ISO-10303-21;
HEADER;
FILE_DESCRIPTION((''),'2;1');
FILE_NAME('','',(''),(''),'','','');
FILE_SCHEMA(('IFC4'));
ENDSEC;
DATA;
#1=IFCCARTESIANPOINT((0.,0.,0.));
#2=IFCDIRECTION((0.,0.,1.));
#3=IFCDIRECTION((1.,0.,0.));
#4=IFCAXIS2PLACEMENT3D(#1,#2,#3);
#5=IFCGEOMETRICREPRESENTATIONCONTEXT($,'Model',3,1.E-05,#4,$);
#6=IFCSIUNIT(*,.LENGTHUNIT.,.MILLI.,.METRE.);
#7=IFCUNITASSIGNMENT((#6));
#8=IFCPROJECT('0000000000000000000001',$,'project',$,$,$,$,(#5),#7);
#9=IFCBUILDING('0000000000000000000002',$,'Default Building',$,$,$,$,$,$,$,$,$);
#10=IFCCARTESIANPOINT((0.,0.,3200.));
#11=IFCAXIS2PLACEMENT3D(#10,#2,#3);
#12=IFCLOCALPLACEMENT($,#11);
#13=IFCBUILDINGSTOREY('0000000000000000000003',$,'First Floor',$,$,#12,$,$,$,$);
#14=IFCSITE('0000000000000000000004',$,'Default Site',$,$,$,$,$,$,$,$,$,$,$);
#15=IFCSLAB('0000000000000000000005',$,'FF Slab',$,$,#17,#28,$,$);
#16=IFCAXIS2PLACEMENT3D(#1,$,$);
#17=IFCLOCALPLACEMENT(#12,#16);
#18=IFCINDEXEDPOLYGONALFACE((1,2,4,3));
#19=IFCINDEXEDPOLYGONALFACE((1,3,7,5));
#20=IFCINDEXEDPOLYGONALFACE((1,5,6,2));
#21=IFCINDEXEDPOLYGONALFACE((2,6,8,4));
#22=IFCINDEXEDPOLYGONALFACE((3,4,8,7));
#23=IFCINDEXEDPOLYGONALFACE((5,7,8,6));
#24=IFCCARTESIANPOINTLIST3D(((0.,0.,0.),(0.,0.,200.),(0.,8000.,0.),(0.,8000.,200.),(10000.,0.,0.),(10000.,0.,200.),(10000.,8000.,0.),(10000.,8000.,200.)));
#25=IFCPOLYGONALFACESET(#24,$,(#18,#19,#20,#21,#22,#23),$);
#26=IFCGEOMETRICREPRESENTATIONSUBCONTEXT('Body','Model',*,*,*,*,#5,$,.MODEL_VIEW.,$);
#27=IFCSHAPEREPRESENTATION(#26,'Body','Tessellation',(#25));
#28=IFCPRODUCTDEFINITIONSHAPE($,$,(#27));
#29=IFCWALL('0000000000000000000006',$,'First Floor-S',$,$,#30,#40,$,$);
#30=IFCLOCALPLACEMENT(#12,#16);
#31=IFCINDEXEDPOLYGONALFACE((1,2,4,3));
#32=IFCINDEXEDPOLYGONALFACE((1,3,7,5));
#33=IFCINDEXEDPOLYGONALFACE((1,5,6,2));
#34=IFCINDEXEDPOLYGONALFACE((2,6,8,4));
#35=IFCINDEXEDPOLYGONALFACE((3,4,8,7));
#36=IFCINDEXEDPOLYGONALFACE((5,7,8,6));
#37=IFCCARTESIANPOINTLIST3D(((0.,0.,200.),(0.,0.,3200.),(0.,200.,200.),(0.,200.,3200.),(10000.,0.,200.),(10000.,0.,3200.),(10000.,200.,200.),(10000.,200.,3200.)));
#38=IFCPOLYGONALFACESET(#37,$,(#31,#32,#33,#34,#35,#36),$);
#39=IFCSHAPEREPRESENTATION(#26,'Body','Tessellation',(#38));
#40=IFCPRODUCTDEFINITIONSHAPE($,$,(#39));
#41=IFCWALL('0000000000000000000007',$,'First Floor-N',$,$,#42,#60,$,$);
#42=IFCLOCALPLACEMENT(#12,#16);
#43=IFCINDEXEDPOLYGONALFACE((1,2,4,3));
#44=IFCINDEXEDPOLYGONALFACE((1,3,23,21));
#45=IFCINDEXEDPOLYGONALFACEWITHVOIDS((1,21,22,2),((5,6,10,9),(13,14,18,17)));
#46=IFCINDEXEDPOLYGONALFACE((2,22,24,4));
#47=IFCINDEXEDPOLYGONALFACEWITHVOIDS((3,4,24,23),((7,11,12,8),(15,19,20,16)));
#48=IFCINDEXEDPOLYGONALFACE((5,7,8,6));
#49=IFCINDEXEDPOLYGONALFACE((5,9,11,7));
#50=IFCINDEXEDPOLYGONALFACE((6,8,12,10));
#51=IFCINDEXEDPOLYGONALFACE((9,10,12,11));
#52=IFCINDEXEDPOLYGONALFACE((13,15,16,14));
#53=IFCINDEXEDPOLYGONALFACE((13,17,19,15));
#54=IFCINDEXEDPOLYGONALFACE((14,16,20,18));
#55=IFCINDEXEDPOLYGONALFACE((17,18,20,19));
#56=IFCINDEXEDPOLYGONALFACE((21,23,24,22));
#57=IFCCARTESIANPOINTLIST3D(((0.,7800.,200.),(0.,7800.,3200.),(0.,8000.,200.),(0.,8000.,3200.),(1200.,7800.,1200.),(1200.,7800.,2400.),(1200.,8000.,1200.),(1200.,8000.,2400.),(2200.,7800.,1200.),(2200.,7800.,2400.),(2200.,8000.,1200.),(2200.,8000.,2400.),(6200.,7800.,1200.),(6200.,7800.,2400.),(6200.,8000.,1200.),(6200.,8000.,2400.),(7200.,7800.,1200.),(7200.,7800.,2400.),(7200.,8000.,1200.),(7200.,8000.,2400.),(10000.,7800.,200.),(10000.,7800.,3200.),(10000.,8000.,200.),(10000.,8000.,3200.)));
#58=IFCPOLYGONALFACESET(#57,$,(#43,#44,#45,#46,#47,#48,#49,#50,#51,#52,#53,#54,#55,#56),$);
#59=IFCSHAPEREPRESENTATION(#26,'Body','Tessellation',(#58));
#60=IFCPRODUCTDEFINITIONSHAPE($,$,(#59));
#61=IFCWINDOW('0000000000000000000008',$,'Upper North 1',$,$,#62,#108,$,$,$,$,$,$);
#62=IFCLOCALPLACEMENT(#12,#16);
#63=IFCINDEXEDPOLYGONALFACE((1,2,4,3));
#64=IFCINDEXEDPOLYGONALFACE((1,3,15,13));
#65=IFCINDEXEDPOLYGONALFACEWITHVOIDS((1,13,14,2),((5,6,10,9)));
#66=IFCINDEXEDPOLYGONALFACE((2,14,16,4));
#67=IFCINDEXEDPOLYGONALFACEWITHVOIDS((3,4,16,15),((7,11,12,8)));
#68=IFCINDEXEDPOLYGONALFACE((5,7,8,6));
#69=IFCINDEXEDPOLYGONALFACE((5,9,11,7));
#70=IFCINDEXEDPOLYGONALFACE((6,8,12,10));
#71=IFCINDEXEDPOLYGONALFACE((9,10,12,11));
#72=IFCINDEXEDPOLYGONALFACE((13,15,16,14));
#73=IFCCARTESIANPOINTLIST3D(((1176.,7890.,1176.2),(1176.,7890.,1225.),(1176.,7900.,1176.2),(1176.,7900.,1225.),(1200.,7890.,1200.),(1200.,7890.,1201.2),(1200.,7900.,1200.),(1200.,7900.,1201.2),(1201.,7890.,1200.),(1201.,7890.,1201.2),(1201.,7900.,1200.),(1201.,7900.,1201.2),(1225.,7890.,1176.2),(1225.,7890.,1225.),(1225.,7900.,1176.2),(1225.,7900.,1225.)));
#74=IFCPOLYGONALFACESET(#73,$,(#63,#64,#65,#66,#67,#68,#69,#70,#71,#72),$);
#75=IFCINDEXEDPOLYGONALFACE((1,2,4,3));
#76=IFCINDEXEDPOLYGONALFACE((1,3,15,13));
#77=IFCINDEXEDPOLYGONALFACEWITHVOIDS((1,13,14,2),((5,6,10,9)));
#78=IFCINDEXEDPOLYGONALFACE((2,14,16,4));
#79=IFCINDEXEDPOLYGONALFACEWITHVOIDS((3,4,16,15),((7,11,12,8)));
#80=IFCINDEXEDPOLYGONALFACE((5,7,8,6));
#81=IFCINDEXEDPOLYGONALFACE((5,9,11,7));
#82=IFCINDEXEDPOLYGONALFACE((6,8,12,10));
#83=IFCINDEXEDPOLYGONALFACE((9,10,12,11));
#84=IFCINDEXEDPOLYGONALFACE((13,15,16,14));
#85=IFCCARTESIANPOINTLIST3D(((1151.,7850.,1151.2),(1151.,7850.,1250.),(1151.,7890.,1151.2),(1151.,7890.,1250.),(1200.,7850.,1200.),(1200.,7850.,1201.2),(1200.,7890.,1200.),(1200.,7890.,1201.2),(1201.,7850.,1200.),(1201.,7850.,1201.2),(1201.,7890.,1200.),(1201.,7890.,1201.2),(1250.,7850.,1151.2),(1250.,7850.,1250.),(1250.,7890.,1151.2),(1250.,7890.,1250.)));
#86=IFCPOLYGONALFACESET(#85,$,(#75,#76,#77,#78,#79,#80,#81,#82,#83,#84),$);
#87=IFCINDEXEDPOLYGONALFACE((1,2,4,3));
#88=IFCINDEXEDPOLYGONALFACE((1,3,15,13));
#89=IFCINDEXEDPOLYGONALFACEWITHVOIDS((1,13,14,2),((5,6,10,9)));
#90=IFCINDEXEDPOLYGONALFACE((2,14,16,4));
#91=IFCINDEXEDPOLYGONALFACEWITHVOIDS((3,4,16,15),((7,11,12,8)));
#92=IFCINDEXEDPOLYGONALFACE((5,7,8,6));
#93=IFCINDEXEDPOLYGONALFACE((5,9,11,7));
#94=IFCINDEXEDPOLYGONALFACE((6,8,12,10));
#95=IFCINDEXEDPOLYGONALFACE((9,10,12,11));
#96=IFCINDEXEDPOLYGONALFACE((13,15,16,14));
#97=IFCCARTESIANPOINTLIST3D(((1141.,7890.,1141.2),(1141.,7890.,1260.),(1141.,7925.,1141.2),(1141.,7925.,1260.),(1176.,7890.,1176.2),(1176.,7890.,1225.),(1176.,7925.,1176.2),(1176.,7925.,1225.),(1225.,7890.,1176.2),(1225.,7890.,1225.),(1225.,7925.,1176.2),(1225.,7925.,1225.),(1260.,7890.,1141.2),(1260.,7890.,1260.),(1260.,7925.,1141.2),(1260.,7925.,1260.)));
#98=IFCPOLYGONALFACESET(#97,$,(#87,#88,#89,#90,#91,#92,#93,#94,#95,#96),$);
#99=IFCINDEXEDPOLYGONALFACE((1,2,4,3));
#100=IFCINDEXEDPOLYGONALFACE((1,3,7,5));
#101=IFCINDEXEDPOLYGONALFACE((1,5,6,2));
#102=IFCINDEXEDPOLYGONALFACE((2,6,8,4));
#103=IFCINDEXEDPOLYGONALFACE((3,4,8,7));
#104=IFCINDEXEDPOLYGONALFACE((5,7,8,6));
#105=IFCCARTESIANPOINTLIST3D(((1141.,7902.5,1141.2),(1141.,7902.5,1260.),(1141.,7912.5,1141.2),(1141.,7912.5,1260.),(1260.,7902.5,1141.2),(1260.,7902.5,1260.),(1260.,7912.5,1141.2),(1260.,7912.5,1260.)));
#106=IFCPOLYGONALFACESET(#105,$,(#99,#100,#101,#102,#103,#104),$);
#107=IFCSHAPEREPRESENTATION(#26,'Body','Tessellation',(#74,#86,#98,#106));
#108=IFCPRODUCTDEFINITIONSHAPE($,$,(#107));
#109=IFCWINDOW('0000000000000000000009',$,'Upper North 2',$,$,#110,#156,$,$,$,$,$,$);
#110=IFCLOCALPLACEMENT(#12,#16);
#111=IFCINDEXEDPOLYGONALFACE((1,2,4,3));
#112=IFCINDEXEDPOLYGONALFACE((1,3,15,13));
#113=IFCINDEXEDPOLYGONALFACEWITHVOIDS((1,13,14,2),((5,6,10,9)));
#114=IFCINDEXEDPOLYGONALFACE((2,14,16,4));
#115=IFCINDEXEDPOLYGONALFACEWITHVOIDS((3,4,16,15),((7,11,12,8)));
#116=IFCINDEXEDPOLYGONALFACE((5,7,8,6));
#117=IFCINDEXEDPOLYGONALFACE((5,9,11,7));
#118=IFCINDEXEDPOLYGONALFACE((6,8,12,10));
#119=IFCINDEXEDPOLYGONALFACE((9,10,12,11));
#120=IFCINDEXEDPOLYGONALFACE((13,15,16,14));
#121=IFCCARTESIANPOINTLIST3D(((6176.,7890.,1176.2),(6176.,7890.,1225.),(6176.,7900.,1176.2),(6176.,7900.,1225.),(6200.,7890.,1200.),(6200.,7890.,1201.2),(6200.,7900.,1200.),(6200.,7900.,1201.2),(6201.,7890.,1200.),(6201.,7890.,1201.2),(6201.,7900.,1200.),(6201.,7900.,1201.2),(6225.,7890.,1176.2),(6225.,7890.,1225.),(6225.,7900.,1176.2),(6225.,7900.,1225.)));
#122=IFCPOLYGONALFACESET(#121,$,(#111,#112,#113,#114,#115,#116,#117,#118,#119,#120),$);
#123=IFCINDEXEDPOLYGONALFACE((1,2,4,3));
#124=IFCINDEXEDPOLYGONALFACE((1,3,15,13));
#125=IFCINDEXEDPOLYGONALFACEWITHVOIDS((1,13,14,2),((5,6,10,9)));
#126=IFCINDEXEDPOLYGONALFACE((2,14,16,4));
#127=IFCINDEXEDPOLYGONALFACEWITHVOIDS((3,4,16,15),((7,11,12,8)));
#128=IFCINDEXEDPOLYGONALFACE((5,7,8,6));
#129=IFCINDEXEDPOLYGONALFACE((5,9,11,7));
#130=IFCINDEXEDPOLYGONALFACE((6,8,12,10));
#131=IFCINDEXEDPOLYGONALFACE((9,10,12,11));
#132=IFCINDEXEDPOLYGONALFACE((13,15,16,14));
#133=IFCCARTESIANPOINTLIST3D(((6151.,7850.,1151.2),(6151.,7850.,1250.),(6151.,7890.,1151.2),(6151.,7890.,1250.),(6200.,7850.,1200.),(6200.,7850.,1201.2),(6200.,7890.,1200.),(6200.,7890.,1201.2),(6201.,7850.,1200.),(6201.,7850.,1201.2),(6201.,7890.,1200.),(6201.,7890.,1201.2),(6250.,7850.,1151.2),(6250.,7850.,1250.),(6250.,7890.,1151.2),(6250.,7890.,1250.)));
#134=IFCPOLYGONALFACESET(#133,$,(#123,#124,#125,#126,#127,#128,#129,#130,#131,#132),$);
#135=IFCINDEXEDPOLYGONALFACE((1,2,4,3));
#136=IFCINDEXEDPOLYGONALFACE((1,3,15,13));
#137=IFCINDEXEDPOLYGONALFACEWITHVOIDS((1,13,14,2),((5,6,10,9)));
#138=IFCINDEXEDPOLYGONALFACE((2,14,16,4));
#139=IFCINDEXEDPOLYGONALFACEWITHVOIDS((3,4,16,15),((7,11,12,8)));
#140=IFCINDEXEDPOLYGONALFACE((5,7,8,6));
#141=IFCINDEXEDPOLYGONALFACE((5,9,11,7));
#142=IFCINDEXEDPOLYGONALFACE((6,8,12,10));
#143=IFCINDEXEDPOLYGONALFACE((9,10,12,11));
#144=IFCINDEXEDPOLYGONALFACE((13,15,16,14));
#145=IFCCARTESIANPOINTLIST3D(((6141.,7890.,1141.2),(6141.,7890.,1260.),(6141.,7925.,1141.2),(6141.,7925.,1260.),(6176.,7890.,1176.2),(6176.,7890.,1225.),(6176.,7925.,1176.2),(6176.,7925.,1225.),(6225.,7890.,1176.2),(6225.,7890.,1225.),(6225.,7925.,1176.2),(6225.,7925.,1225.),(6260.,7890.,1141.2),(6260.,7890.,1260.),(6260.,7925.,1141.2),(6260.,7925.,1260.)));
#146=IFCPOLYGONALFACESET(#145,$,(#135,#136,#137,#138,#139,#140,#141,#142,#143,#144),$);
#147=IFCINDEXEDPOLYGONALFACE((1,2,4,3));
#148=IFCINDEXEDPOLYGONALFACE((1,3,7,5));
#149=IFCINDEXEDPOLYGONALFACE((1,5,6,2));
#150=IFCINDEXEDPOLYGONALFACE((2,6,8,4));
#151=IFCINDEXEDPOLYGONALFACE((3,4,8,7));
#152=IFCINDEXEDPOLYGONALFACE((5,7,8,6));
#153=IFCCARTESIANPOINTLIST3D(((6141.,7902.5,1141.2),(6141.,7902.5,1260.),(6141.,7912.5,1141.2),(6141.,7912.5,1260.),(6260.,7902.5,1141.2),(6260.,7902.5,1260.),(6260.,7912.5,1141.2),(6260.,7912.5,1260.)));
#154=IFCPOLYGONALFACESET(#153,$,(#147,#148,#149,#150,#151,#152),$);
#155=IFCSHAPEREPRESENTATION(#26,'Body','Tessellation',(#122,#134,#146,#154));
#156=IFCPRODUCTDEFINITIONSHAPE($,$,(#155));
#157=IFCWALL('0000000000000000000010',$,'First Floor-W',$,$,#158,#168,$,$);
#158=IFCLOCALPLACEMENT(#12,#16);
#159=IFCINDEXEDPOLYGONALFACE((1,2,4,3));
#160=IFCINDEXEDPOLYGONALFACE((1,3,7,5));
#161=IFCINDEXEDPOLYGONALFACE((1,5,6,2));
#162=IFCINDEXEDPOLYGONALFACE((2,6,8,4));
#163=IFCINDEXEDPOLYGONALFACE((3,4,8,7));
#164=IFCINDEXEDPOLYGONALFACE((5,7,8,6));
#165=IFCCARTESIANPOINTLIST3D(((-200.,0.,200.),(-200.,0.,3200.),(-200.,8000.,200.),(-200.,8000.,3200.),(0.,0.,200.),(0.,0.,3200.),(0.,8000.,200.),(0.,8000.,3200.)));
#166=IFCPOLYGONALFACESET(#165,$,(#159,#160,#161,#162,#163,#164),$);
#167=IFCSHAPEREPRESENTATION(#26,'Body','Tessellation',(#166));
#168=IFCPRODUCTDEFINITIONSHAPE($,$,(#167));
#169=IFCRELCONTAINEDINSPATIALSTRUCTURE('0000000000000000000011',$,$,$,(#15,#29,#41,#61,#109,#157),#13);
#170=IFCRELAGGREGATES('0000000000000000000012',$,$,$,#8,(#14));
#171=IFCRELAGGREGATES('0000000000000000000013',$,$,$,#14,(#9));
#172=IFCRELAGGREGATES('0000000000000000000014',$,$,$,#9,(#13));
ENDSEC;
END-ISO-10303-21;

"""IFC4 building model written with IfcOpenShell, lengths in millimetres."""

from ifc_helpers import new_model, si_unit, frame, origin_with_axes, place, context, subcontext, project, spatial, line, indexed_curve, outline, extrude, element, fill, save


model = new_model("IFC4")

# Units and contexts
model_context = context("Model", 3, precision=1e-05, world=origin_with_axes())
body_context = subcontext(model_context, "Body", "Model", "MODEL_VIEW")
ifc_project = project(units=[si_unit("LENGTHUNIT", "METRE", prefix="MILLI")], contexts=[model_context])

# Site, building, storey
site = spatial("IfcSite", under=ifc_project, Name="Default Site")
building = spatial("IfcBuilding", under=site, Name="Default Building")
storey_placement = place(None, frame((0.0, 0.0, 3200.0), z_axis=(0.0, 0.0, 1.0), x_axis=(1.0, 0.0, 0.0)))
storey = spatial("IfcBuildingStorey", under=building, at=storey_placement, Name="First Floor")

# Slab
slab_placement = place(storey_placement, origin_with_axes())
element("IfcSlab", 1, at=slab_placement, inside=storey, Name="FF Slab", context=body_context, shape_type="SweptSolid", body=[
    extrude(outline(indexed_curve([(0.0, 0.0), (10000.0, 0.0), (10000.0, 8000.0), (0.0, 8000.0), (0.0, 0.0)])), None, (0.0, 0.0, 1.0), 200.0),
])

# Wall
wall_1_placement = place(storey_placement, frame((0.0, 0.0, 200.0), z_axis=(0.0, 0.0, 1.0), x_axis=(1.0, 0.0, 0.0)))
element("IfcWall", 2, at=wall_1_placement, inside=storey, Name="First Floor-S", context=body_context, shape_type="SweptSolid", body=[
    extrude(outline(indexed_curve([(0.0, 0.0), (10000.0, 0.0), (10000.0, 200.0), (0.0, 200.0), (0.0, 0.0)])), None, (0.0, 0.0, 1.0), 3000.0),
])

# Wall, openings, windows
wall_2_placement = place(storey_placement, frame((0.0, 0.0, 200.0), z_axis=(0.0, 0.0, 1.0), x_axis=(1.0, 0.0, 0.0)))
wall_2 = element("IfcWall", 3, at=wall_2_placement, inside=storey, Name="First Floor-N", context=body_context, shape_type="SweptSolid", body=[
    extrude(outline(indexed_curve([(0.0, 7800.0), (10000.0, 7800.0), (10000.0, 8000.0), (0.0, 8000.0), (0.0, 7800.0)])), None, (0.0, 0.0, 1.0), 3000.0),
])
opening_1_placement = place(wall_2_placement, frame((0.0, 0.0, 1000.0), z_axis=(0.0, 0.0, 1.0), x_axis=(1.0, 0.0, 0.0)))
opening_1 = element("IfcOpeningElement", 4, at=opening_1_placement, cuts=wall_2, context=body_context, shape_type="SweptSolid", body=[
    extrude(outline(indexed_curve([(1200.0, 7800.0), (2200.0, 7800.0), (2200.0, 8000.0), (1200.0, 8000.0), (1200.0, 7800.0)])), None, (0.0, 0.0, 1.0), 1200.0),
])
opening_2_placement = place(wall_2_placement, frame((0.0, 0.0, 1000.0), z_axis=(0.0, 0.0, 1.0), x_axis=(1.0, 0.0, 0.0)))
opening_2 = element("IfcOpeningElement", 5, at=opening_2_placement, cuts=wall_2, context=body_context, shape_type="SweptSolid", body=[
    extrude(outline(indexed_curve([(6200.0, 7800.0), (7200.0, 7800.0), (7200.0, 8000.0), (6200.0, 8000.0), (6200.0, 7800.0)])), None, (0.0, 0.0, 1.0), 1200.0),
])
window_1_placement = place(storey_placement, frame((1200.0, 7800.0, 1200.0), z_axis=(0.0, 0.0, 1.0), x_axis=(1.0, 0.0, 0.0)))
window_1 = element("IfcWindow", 6, at=window_1_placement, inside=storey, Name="Upper North 1", context=body_context, shape_type="SweptSolid", body=[
    extrude(outline(indexed_curve([(0.0, 0.0), (1.0, 0.0), (1.0, 1.2), (0.0, 1.2)], segments=[line(1, 2, 3, 4, 1)]), holes=[indexed_curve([(25.0, 25.0), (-24.0, 25.0), (-24.0, -23.8), (25.0, -23.8)], segments=[line(1, 2, 3, 4, 1)])]), frame((0.0, 90.0, 0.0), z_axis=(0.0, -1.0, 0.0), x_axis=(1.0, 0.0, 0.0)), (0.0, 0.0, -1.0), 10.0),
    extrude(outline(indexed_curve([(0.0, 0.0), (1.0, 0.0), (1.0, 1.2), (0.0, 1.2)], segments=[line(1, 2, 3, 4, 1)]), holes=[indexed_curve([(50.0, 50.0), (-49.0, 50.0), (-49.0, -48.8), (50.0, -48.8)], segments=[line(1, 2, 3, 4, 1)])]), frame((0.0, 50.0, 0.0), z_axis=(0.0, -1.0, 0.0), x_axis=(1.0, 0.0, 0.0)), (0.0, 0.0, -1.0), 40.0),
    extrude(outline(indexed_curve([(0.0, 0.0), (-49.0, 0.0), (-49.0, -48.8), (0.0, -48.8)], segments=[line(1, 2, 3, 4, 1)]), holes=[indexed_curve([(35.0, 35.0), (-84.0, 35.0), (-84.0, -83.8), (35.0, -83.8)], segments=[line(1, 2, 3, 4, 1)])]), frame((25.0, 90.0, 25.0), z_axis=(0.0, -1.0, 0.0), x_axis=(1.0, 0.0, 0.0)), (0.0, 0.0, -1.0), 35.0),
    extrude(outline(indexed_curve([(35.0, 35.0), (-84.0, 35.0), (-84.0, -83.8), (35.0, -83.8)], segments=[line(1, 2, 3, 4, 1)])), frame((25.0, 102.5, 25.0), z_axis=(0.0, -1.0, 0.0), x_axis=(1.0, 0.0, 0.0)), (0.0, 0.0, -1.0), 10.0),
])
fill(opening_1, window_1)
window_2_placement = place(storey_placement, frame((6200.0, 7800.0, 1200.0), z_axis=(0.0, 0.0, 1.0), x_axis=(1.0, 0.0, 0.0)))
window_2 = element("IfcWindow", 7, at=window_2_placement, inside=storey, Name="Upper North 2", context=body_context, shape_type="SweptSolid", body=[
    extrude(outline(indexed_curve([(0.0, 0.0), (1.0, 0.0), (1.0, 1.2), (0.0, 1.2)], segments=[line(1, 2, 3, 4, 1)]), holes=[indexed_curve([(25.0, 25.0), (-24.0, 25.0), (-24.0, -23.8), (25.0, -23.8)], segments=[line(1, 2, 3, 4, 1)])]), frame((0.0, 90.0, 0.0), z_axis=(0.0, -1.0, 0.0), x_axis=(1.0, 0.0, 0.0)), (0.0, 0.0, -1.0), 10.0),
    extrude(outline(indexed_curve([(0.0, 0.0), (1.0, 0.0), (1.0, 1.2), (0.0, 1.2)], segments=[line(1, 2, 3, 4, 1)]), holes=[indexed_curve([(50.0, 50.0), (-49.0, 50.0), (-49.0, -48.8), (50.0, -48.8)], segments=[line(1, 2, 3, 4, 1)])]), frame((0.0, 50.0, 0.0), z_axis=(0.0, -1.0, 0.0), x_axis=(1.0, 0.0, 0.0)), (0.0, 0.0, -1.0), 40.0),
    extrude(outline(indexed_curve([(0.0, 0.0), (-49.0, 0.0), (-49.0, -48.8), (0.0, -48.8)], segments=[line(1, 2, 3, 4, 1)]), holes=[indexed_curve([(35.0, 35.0), (-84.0, 35.0), (-84.0, -83.8), (35.0, -83.8)], segments=[line(1, 2, 3, 4, 1)])]), frame((25.0, 90.0, 25.0), z_axis=(0.0, -1.0, 0.0), x_axis=(1.0, 0.0, 0.0)), (0.0, 0.0, -1.0), 35.0),
    extrude(outline(indexed_curve([(35.0, 35.0), (-84.0, 35.0), (-84.0, -83.8), (35.0, -83.8)], segments=[line(1, 2, 3, 4, 1)])), frame((25.0, 102.5, 25.0), z_axis=(0.0, -1.0, 0.0), x_axis=(1.0, 0.0, 0.0)), (0.0, 0.0, -1.0), 10.0),
])
fill(opening_2, window_2)

# Wall
wall_3_placement = place(storey_placement, frame((0.0, 0.0, 200.0), z_axis=(0.0, 0.0, 1.0), x_axis=(1.0, 0.0, 0.0)))
element("IfcWall", 8, at=wall_3_placement, inside=storey, Name="First Floor-W", context=body_context, shape_type="SweptSolid", body=[
    extrude(outline(indexed_curve([(0.0, 0.0), (0.0, 8000.0), (-200.0, 8000.0), (-200.0, 0.0), (0.0, 0.0)])), None, (0.0, 0.0, 1.0), 3000.0),
])

save(model, "model.ifc")
